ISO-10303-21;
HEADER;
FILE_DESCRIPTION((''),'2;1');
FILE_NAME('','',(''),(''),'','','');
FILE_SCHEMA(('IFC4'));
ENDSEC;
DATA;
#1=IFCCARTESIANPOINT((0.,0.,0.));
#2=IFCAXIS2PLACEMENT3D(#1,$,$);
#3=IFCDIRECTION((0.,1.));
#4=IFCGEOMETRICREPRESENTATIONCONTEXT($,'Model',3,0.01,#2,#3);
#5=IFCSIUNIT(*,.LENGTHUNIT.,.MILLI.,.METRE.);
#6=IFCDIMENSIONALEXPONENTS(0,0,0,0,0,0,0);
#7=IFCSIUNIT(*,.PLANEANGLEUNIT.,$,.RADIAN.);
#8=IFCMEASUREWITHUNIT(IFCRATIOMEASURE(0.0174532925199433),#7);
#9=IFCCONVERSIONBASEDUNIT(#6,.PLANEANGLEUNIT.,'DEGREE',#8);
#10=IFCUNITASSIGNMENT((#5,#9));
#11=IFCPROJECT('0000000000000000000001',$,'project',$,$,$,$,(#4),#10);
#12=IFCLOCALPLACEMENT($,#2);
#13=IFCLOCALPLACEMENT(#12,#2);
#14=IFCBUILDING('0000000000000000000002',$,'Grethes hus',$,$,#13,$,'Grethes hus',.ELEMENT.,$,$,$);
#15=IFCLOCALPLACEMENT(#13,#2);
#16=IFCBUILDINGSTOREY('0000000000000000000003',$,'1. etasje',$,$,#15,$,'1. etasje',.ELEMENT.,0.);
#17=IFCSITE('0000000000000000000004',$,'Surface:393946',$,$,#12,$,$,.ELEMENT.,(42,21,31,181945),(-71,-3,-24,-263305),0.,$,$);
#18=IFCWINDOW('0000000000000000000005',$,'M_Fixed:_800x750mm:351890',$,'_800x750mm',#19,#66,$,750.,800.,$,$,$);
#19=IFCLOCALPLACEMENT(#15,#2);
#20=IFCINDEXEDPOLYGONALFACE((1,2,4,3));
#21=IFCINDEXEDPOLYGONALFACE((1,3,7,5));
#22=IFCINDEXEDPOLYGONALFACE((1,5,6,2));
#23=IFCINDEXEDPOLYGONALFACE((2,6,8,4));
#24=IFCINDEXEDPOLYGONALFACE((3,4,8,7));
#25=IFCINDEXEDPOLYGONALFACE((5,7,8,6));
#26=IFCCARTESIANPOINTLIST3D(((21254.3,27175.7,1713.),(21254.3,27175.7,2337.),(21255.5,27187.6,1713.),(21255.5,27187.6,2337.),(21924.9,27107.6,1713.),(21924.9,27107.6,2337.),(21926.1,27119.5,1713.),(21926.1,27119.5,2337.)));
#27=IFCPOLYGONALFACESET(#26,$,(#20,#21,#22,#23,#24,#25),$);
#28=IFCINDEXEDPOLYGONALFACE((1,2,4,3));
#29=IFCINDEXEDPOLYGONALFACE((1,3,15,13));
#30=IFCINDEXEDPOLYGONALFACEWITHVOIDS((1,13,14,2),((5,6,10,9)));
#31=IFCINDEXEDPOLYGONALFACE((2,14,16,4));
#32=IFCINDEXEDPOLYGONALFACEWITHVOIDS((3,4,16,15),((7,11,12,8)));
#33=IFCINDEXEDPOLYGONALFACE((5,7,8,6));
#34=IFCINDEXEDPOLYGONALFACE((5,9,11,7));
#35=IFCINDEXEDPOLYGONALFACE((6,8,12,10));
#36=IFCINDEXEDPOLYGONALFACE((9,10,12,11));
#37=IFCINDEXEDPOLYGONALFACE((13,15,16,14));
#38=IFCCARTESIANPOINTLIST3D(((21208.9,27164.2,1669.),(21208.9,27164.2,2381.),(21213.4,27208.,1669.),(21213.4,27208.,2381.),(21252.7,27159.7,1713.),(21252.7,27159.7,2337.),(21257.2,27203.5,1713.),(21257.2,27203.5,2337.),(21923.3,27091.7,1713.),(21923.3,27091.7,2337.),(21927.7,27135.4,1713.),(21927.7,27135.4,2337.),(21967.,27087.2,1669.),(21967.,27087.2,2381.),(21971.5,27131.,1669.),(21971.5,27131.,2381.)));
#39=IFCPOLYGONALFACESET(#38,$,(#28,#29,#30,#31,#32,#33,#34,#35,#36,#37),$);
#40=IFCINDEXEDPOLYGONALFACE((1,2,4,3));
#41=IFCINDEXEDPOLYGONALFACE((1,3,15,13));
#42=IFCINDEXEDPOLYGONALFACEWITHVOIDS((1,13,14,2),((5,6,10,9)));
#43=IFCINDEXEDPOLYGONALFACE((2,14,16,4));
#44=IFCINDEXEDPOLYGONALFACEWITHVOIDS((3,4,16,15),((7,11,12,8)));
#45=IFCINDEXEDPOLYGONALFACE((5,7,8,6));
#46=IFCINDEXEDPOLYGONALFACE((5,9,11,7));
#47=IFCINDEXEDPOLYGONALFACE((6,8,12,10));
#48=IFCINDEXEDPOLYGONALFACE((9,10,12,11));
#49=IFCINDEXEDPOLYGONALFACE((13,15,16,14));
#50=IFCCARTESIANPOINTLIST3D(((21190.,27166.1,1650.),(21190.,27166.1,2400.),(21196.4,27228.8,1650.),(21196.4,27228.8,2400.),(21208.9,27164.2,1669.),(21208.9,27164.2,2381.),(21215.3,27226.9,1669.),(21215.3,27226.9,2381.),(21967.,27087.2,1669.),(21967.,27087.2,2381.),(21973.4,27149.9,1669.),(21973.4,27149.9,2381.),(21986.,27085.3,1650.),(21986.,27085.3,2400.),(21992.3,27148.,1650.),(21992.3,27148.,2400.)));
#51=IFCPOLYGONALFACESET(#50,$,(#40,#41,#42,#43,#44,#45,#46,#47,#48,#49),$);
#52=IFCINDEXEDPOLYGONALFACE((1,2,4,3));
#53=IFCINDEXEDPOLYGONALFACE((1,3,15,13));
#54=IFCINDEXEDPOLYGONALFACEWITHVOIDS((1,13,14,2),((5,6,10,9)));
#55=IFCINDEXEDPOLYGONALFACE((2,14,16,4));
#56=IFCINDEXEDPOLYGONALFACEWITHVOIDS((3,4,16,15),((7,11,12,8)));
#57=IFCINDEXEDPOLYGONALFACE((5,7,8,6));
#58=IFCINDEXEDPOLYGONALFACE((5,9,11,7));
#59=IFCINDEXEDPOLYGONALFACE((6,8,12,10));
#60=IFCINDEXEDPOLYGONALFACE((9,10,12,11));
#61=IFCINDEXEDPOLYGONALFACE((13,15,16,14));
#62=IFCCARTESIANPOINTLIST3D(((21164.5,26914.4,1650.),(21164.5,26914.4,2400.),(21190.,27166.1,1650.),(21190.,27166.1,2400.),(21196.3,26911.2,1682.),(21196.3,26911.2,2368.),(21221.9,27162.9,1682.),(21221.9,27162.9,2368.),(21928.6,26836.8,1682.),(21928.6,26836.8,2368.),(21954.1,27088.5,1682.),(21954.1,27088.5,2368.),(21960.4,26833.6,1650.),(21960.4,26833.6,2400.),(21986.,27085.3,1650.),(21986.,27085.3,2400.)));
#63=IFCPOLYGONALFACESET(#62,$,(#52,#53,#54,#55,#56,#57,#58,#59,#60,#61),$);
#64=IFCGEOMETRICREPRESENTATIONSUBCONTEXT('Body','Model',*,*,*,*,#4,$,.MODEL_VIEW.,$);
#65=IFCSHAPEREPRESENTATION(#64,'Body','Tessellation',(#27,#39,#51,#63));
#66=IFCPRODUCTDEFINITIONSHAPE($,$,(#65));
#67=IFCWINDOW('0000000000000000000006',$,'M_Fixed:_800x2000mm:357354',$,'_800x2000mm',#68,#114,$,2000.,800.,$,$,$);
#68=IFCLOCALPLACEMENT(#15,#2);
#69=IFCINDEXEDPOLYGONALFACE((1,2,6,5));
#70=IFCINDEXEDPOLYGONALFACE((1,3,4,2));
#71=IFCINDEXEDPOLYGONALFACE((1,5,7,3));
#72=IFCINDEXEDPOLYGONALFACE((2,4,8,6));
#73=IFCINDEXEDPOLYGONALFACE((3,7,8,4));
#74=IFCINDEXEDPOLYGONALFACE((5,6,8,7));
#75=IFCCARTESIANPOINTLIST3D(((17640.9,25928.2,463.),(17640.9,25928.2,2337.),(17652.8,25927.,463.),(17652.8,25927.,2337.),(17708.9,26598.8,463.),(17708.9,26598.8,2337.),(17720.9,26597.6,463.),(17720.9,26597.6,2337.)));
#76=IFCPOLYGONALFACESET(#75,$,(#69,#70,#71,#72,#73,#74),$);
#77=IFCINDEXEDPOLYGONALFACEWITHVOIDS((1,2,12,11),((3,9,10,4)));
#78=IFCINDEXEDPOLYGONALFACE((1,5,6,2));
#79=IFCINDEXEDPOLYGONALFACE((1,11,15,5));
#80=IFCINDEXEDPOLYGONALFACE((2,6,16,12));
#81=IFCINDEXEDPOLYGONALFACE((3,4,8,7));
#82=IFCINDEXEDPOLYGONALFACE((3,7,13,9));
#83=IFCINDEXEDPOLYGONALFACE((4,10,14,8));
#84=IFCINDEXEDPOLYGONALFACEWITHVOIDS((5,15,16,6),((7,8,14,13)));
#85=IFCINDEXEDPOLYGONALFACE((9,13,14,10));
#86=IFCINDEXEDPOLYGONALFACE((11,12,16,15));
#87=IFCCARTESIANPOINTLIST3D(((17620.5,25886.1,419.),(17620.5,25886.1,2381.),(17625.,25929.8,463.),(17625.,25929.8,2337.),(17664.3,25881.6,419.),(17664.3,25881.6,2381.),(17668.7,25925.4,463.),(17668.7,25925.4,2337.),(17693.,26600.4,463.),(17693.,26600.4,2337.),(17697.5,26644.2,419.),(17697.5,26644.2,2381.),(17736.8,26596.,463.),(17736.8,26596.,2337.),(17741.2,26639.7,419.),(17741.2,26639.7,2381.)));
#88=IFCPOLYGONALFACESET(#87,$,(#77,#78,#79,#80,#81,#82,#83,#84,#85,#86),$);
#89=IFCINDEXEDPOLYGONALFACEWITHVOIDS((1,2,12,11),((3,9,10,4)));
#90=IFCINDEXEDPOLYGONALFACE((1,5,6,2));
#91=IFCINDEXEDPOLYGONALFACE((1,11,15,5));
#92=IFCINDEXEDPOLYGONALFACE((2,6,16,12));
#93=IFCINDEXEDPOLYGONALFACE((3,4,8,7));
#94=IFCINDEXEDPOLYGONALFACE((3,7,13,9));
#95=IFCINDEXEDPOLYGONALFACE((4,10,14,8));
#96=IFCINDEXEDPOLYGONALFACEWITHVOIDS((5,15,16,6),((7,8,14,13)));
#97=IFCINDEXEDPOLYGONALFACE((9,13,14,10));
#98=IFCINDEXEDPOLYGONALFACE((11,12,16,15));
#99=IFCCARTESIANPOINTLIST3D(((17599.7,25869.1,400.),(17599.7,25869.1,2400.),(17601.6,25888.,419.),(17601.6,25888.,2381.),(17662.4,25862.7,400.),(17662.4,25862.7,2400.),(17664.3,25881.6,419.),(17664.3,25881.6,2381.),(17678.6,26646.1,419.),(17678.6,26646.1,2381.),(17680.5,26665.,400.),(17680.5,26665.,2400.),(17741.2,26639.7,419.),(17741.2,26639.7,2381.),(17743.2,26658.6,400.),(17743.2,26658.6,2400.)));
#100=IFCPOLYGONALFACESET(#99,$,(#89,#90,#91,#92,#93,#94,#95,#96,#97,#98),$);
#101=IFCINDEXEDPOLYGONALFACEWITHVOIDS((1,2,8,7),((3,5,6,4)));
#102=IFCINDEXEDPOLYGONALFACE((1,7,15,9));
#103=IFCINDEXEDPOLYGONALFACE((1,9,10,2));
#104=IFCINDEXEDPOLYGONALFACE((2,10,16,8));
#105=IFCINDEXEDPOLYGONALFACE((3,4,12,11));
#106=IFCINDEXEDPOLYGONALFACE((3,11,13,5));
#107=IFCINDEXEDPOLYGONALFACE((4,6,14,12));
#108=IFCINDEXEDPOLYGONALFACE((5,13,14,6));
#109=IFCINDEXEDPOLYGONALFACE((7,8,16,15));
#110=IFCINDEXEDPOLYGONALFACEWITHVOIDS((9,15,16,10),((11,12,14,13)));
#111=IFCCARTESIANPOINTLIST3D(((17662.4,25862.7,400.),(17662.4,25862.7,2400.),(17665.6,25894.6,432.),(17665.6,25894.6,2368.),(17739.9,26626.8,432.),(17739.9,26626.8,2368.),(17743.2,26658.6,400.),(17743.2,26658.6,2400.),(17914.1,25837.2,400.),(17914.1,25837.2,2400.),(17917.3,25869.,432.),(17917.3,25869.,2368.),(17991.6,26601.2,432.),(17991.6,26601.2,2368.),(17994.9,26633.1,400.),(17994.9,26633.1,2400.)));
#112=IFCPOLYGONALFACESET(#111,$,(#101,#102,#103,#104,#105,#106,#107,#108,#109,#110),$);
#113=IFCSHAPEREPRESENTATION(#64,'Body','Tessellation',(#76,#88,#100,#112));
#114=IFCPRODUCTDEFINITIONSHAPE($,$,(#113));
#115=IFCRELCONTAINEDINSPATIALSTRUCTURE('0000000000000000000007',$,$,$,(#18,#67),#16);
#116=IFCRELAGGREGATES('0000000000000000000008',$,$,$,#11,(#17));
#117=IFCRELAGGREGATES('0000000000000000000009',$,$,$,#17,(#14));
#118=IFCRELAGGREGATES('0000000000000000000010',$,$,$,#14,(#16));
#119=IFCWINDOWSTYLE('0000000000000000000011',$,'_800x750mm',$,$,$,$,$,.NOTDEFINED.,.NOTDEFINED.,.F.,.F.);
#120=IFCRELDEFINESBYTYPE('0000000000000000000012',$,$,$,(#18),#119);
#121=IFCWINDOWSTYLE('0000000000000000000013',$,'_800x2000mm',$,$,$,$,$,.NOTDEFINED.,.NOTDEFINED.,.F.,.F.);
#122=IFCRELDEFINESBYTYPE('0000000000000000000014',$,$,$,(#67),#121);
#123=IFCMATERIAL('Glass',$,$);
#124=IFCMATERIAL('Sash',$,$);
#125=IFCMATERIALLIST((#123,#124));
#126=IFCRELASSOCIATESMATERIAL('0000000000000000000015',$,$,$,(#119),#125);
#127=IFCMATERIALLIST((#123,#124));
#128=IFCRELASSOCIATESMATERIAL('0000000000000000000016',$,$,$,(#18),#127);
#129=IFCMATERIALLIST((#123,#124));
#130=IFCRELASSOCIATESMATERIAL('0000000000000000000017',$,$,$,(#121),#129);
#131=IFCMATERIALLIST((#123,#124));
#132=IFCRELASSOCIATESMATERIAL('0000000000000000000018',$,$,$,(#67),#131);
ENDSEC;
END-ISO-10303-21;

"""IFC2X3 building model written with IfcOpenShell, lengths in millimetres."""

from ifc_helpers import new_model, entity, si_unit, converted_unit, direction, frame, frame_2d, origin, place, context, subcontext, project, spatial, polyline, rectangle, outline, extrude, source, transform, mapped, material, material_list, type_object, type_shapes, element, save


model = new_model("IFC2X3")

# Units and contexts
model_context = context("Model", 3, precision=0.01, world=origin(), true_north=direction((0.0, 1.0)))
body_context = subcontext(model_context, "Body", "Model", "MODEL_VIEW")
ifc_project = project(units=[si_unit("LENGTHUNIT", "METRE", prefix="MILLI"), converted_unit("PLANEANGLEUNIT", "DEGREE", entity("IfcRatioMeasure", 0.0174532925199433), si_unit("PLANEANGLEUNIT", "RADIAN"), dimensions=[0, 0, 0, 0, 0, 0, 0])], contexts=[model_context])

# Site, building, storey
site_placement = place(None, origin())
site = spatial("IfcSite", under=ifc_project, at=site_placement, Name="Surface:393946", CompositionType="ELEMENT", RefLatitude=(42, 21, 31, 181945), RefLongitude=(-71, -3, -24, -263305), RefElevation=0.0)
building_placement = place(site_placement, origin())
building = spatial("IfcBuilding", under=site, at=building_placement, Name="Grethes hus", LongName="Grethes hus", CompositionType="ELEMENT")
storey_placement = place(building_placement, origin())
storey = spatial("IfcBuildingStorey", under=building, at=storey_placement, Name="1. etasje", LongName="1. etasje", CompositionType="ELEMENT", Elevation=0.0)

# Shared definitions
ifc_material_1 = material(Name="Glass")
ifc_material_2 = material(Name="Sash")

# Shared definitions
placement_1 = place(storey_placement, frame((17757.0, 27419.1, 400.0), z_axis=(0.0, 0.0, 1.0), x_axis=(0.994887, -0.100996, 0.0)))

# Windows
ifc_material_list_1 = material_list([ifc_material_1, ifc_material_2])
ifc_material_list_2 = material_list([ifc_material_1, ifc_material_2])
window_style_1 = type_object("IfcWindowStyle", Name="_800x750mm", ConstructionType="NOTDEFINED", OperationType="NOTDEFINED", ParameterTakesPrecedence=False, Sizeable=False, material=ifc_material_list_2)
shared_shape_1 = source(origin(), body_context, "Body", "SweptSolid", [
    extrude(rectangle(XDim=12.0, YDim=674.0, at=frame_2d((0.0, 0.0), x_axis=(1.0, 0.0))), frame((400.0, 275.0, 63.0), z_axis=(0.0, 0.0, 1.0), x_axis=(0.0, -1.0, 0.0)), (0.0, 0.0, 1.0), 624.0),
    extrude(outline(polyline([(-381.0, -356.0), (381.0, -356.0), (381.0, 356.0), (-381.0, 356.0), (-381.0, -356.0)]), holes=[polyline([(-337.0, -312.0), (-337.0, 312.0), (337.0, 312.0), (337.0, -312.0), (-337.0, -312.0)])]), frame((400.0, 253.0, 375.0), z_axis=(0.0, 1.0, 0.0), x_axis=(1.0, 0.0, 0.0)), (0.0, 0.0, 1.0), 44.0),
    extrude(outline(polyline([(-400.0, -375.0), (400.0, -375.0), (400.0, 375.0), (-400.0, 375.0), (-400.0, -375.0)]), holes=[polyline([(-381.0, -356.0), (-381.0, 356.0), (381.0, 356.0), (381.0, -356.0), (-381.0, -356.0)])]), frame((400.0, 253.0, 375.0), z_axis=(0.0, 1.0, 0.0), x_axis=(1.0, 0.0, 0.0)), (0.0, 0.0, 1.0), 63.0),
    extrude(outline(polyline([(-400.0, -375.0), (400.0, -375.0), (400.0, 375.0), (-400.0, 375.0), (-400.0, -375.0)]), holes=[polyline([(-368.0, -343.0), (-368.0, 343.0), (368.0, 343.0), (368.0, -343.0), (-368.0, -343.0)])]), frame((400.0, 0.0, 375.0), z_axis=(0.0, 1.0, 0.0), x_axis=(1.0, 0.0, 0.0)), (0.0, 0.0, 1.0), 253.0),
])
type_shapes(window_style_1, [shared_shape_1])
placement_2 = place(placement_1, frame((3441.0, -158.0, 1250.0)))
window_1_placement = place(placement_2, origin())
element("IfcWindow", 1, at=window_1_placement, inside=storey, type_object=window_style_1, material=ifc_material_list_1, Name="M_Fixed:_800x750mm:351890", ObjectType="_800x750mm", OverallHeight=750.0, OverallWidth=800.0, context=body_context, shape_type="MappedRepresentation", body=[
    mapped(shared_shape_1, transform((0.0, 0.0, 0.0), scale=1.0)),
])
ifc_material_list_3 = material_list([ifc_material_1, ifc_material_2])
ifc_material_list_4 = material_list([ifc_material_1, ifc_material_2])
window_style_2 = type_object("IfcWindowStyle", Name="_800x2000mm", ConstructionType="NOTDEFINED", OperationType="NOTDEFINED", ParameterTakesPrecedence=False, Sizeable=False, material=ifc_material_list_4)
shared_shape_2 = source(origin(), body_context, "Body", "SweptSolid", [
    extrude(rectangle(XDim=12.0, YDim=674.0, at=frame_2d((0.0, 0.0), x_axis=(1.0, 0.0))), frame((400.0, 275.0, 63.0), z_axis=(0.0, 0.0, 1.0), x_axis=(0.0, -1.0, 0.0)), (0.0, 0.0, 1.0), 1874.0),
    extrude(outline(polyline([(-381.0, -981.0), (381.0, -981.0), (381.0, 981.0), (-381.0, 981.0), (-381.0, -981.0)]), holes=[polyline([(-337.0, -937.0), (-337.0, 937.0), (337.0, 937.0), (337.0, -937.0), (-337.0, -937.0)])]), frame((400.0, 253.0, 1000.0), z_axis=(0.0, 1.0, 0.0), x_axis=(1.0, 0.0, 0.0)), (0.0, 0.0, 1.0), 44.0),
    extrude(outline(polyline([(-400.0, -1000.0), (400.0, -1000.0), (400.0, 1000.0), (-400.0, 1000.0), (-400.0, -1000.0)]), holes=[polyline([(-381.0, -981.0), (-381.0, 981.0), (381.0, 981.0), (381.0, -981.0), (-381.0, -981.0)])]), frame((400.0, 253.0, 1000.0), z_axis=(0.0, 1.0, 0.0), x_axis=(1.0, 0.0, 0.0)), (0.0, 0.0, 1.0), 63.0),
    extrude(outline(polyline([(-400.0, -1000.0), (400.0, -1000.0), (400.0, 1000.0), (-400.0, 1000.0), (-400.0, -1000.0)]), holes=[polyline([(-368.0, -968.0), (-368.0, 968.0), (368.0, 968.0), (368.0, -968.0), (-368.0, -968.0)])]), frame((400.0, 0.0, 1000.0), z_axis=(0.0, 1.0, 0.0), x_axis=(1.0, 0.0, 0.0)), (0.0, 0.0, 1.0), 253.0),
])
type_shapes(window_style_2, [shared_shape_2])
placement_3 = place(storey_placement, frame((16949.1, 17896.0, 0.0), z_axis=(0.0, 0.0, 1.0), x_axis=(0.100996, 0.994887, 0.0)))
placement_4 = place(placement_3, frame((7998.0, -158.0, 400.0)))
window_2_placement = place(placement_4, origin())
element("IfcWindow", 2, at=window_2_placement, inside=storey, type_object=window_style_2, material=ifc_material_list_3, Name="M_Fixed:_800x2000mm:357354", ObjectType="_800x2000mm", OverallHeight=2000.0, OverallWidth=800.0, context=body_context, shape_type="MappedRepresentation", body=[
    mapped(shared_shape_2, transform((0.0, 0.0, 0.0), scale=1.0)),
])

save(model, "model.ifc")
